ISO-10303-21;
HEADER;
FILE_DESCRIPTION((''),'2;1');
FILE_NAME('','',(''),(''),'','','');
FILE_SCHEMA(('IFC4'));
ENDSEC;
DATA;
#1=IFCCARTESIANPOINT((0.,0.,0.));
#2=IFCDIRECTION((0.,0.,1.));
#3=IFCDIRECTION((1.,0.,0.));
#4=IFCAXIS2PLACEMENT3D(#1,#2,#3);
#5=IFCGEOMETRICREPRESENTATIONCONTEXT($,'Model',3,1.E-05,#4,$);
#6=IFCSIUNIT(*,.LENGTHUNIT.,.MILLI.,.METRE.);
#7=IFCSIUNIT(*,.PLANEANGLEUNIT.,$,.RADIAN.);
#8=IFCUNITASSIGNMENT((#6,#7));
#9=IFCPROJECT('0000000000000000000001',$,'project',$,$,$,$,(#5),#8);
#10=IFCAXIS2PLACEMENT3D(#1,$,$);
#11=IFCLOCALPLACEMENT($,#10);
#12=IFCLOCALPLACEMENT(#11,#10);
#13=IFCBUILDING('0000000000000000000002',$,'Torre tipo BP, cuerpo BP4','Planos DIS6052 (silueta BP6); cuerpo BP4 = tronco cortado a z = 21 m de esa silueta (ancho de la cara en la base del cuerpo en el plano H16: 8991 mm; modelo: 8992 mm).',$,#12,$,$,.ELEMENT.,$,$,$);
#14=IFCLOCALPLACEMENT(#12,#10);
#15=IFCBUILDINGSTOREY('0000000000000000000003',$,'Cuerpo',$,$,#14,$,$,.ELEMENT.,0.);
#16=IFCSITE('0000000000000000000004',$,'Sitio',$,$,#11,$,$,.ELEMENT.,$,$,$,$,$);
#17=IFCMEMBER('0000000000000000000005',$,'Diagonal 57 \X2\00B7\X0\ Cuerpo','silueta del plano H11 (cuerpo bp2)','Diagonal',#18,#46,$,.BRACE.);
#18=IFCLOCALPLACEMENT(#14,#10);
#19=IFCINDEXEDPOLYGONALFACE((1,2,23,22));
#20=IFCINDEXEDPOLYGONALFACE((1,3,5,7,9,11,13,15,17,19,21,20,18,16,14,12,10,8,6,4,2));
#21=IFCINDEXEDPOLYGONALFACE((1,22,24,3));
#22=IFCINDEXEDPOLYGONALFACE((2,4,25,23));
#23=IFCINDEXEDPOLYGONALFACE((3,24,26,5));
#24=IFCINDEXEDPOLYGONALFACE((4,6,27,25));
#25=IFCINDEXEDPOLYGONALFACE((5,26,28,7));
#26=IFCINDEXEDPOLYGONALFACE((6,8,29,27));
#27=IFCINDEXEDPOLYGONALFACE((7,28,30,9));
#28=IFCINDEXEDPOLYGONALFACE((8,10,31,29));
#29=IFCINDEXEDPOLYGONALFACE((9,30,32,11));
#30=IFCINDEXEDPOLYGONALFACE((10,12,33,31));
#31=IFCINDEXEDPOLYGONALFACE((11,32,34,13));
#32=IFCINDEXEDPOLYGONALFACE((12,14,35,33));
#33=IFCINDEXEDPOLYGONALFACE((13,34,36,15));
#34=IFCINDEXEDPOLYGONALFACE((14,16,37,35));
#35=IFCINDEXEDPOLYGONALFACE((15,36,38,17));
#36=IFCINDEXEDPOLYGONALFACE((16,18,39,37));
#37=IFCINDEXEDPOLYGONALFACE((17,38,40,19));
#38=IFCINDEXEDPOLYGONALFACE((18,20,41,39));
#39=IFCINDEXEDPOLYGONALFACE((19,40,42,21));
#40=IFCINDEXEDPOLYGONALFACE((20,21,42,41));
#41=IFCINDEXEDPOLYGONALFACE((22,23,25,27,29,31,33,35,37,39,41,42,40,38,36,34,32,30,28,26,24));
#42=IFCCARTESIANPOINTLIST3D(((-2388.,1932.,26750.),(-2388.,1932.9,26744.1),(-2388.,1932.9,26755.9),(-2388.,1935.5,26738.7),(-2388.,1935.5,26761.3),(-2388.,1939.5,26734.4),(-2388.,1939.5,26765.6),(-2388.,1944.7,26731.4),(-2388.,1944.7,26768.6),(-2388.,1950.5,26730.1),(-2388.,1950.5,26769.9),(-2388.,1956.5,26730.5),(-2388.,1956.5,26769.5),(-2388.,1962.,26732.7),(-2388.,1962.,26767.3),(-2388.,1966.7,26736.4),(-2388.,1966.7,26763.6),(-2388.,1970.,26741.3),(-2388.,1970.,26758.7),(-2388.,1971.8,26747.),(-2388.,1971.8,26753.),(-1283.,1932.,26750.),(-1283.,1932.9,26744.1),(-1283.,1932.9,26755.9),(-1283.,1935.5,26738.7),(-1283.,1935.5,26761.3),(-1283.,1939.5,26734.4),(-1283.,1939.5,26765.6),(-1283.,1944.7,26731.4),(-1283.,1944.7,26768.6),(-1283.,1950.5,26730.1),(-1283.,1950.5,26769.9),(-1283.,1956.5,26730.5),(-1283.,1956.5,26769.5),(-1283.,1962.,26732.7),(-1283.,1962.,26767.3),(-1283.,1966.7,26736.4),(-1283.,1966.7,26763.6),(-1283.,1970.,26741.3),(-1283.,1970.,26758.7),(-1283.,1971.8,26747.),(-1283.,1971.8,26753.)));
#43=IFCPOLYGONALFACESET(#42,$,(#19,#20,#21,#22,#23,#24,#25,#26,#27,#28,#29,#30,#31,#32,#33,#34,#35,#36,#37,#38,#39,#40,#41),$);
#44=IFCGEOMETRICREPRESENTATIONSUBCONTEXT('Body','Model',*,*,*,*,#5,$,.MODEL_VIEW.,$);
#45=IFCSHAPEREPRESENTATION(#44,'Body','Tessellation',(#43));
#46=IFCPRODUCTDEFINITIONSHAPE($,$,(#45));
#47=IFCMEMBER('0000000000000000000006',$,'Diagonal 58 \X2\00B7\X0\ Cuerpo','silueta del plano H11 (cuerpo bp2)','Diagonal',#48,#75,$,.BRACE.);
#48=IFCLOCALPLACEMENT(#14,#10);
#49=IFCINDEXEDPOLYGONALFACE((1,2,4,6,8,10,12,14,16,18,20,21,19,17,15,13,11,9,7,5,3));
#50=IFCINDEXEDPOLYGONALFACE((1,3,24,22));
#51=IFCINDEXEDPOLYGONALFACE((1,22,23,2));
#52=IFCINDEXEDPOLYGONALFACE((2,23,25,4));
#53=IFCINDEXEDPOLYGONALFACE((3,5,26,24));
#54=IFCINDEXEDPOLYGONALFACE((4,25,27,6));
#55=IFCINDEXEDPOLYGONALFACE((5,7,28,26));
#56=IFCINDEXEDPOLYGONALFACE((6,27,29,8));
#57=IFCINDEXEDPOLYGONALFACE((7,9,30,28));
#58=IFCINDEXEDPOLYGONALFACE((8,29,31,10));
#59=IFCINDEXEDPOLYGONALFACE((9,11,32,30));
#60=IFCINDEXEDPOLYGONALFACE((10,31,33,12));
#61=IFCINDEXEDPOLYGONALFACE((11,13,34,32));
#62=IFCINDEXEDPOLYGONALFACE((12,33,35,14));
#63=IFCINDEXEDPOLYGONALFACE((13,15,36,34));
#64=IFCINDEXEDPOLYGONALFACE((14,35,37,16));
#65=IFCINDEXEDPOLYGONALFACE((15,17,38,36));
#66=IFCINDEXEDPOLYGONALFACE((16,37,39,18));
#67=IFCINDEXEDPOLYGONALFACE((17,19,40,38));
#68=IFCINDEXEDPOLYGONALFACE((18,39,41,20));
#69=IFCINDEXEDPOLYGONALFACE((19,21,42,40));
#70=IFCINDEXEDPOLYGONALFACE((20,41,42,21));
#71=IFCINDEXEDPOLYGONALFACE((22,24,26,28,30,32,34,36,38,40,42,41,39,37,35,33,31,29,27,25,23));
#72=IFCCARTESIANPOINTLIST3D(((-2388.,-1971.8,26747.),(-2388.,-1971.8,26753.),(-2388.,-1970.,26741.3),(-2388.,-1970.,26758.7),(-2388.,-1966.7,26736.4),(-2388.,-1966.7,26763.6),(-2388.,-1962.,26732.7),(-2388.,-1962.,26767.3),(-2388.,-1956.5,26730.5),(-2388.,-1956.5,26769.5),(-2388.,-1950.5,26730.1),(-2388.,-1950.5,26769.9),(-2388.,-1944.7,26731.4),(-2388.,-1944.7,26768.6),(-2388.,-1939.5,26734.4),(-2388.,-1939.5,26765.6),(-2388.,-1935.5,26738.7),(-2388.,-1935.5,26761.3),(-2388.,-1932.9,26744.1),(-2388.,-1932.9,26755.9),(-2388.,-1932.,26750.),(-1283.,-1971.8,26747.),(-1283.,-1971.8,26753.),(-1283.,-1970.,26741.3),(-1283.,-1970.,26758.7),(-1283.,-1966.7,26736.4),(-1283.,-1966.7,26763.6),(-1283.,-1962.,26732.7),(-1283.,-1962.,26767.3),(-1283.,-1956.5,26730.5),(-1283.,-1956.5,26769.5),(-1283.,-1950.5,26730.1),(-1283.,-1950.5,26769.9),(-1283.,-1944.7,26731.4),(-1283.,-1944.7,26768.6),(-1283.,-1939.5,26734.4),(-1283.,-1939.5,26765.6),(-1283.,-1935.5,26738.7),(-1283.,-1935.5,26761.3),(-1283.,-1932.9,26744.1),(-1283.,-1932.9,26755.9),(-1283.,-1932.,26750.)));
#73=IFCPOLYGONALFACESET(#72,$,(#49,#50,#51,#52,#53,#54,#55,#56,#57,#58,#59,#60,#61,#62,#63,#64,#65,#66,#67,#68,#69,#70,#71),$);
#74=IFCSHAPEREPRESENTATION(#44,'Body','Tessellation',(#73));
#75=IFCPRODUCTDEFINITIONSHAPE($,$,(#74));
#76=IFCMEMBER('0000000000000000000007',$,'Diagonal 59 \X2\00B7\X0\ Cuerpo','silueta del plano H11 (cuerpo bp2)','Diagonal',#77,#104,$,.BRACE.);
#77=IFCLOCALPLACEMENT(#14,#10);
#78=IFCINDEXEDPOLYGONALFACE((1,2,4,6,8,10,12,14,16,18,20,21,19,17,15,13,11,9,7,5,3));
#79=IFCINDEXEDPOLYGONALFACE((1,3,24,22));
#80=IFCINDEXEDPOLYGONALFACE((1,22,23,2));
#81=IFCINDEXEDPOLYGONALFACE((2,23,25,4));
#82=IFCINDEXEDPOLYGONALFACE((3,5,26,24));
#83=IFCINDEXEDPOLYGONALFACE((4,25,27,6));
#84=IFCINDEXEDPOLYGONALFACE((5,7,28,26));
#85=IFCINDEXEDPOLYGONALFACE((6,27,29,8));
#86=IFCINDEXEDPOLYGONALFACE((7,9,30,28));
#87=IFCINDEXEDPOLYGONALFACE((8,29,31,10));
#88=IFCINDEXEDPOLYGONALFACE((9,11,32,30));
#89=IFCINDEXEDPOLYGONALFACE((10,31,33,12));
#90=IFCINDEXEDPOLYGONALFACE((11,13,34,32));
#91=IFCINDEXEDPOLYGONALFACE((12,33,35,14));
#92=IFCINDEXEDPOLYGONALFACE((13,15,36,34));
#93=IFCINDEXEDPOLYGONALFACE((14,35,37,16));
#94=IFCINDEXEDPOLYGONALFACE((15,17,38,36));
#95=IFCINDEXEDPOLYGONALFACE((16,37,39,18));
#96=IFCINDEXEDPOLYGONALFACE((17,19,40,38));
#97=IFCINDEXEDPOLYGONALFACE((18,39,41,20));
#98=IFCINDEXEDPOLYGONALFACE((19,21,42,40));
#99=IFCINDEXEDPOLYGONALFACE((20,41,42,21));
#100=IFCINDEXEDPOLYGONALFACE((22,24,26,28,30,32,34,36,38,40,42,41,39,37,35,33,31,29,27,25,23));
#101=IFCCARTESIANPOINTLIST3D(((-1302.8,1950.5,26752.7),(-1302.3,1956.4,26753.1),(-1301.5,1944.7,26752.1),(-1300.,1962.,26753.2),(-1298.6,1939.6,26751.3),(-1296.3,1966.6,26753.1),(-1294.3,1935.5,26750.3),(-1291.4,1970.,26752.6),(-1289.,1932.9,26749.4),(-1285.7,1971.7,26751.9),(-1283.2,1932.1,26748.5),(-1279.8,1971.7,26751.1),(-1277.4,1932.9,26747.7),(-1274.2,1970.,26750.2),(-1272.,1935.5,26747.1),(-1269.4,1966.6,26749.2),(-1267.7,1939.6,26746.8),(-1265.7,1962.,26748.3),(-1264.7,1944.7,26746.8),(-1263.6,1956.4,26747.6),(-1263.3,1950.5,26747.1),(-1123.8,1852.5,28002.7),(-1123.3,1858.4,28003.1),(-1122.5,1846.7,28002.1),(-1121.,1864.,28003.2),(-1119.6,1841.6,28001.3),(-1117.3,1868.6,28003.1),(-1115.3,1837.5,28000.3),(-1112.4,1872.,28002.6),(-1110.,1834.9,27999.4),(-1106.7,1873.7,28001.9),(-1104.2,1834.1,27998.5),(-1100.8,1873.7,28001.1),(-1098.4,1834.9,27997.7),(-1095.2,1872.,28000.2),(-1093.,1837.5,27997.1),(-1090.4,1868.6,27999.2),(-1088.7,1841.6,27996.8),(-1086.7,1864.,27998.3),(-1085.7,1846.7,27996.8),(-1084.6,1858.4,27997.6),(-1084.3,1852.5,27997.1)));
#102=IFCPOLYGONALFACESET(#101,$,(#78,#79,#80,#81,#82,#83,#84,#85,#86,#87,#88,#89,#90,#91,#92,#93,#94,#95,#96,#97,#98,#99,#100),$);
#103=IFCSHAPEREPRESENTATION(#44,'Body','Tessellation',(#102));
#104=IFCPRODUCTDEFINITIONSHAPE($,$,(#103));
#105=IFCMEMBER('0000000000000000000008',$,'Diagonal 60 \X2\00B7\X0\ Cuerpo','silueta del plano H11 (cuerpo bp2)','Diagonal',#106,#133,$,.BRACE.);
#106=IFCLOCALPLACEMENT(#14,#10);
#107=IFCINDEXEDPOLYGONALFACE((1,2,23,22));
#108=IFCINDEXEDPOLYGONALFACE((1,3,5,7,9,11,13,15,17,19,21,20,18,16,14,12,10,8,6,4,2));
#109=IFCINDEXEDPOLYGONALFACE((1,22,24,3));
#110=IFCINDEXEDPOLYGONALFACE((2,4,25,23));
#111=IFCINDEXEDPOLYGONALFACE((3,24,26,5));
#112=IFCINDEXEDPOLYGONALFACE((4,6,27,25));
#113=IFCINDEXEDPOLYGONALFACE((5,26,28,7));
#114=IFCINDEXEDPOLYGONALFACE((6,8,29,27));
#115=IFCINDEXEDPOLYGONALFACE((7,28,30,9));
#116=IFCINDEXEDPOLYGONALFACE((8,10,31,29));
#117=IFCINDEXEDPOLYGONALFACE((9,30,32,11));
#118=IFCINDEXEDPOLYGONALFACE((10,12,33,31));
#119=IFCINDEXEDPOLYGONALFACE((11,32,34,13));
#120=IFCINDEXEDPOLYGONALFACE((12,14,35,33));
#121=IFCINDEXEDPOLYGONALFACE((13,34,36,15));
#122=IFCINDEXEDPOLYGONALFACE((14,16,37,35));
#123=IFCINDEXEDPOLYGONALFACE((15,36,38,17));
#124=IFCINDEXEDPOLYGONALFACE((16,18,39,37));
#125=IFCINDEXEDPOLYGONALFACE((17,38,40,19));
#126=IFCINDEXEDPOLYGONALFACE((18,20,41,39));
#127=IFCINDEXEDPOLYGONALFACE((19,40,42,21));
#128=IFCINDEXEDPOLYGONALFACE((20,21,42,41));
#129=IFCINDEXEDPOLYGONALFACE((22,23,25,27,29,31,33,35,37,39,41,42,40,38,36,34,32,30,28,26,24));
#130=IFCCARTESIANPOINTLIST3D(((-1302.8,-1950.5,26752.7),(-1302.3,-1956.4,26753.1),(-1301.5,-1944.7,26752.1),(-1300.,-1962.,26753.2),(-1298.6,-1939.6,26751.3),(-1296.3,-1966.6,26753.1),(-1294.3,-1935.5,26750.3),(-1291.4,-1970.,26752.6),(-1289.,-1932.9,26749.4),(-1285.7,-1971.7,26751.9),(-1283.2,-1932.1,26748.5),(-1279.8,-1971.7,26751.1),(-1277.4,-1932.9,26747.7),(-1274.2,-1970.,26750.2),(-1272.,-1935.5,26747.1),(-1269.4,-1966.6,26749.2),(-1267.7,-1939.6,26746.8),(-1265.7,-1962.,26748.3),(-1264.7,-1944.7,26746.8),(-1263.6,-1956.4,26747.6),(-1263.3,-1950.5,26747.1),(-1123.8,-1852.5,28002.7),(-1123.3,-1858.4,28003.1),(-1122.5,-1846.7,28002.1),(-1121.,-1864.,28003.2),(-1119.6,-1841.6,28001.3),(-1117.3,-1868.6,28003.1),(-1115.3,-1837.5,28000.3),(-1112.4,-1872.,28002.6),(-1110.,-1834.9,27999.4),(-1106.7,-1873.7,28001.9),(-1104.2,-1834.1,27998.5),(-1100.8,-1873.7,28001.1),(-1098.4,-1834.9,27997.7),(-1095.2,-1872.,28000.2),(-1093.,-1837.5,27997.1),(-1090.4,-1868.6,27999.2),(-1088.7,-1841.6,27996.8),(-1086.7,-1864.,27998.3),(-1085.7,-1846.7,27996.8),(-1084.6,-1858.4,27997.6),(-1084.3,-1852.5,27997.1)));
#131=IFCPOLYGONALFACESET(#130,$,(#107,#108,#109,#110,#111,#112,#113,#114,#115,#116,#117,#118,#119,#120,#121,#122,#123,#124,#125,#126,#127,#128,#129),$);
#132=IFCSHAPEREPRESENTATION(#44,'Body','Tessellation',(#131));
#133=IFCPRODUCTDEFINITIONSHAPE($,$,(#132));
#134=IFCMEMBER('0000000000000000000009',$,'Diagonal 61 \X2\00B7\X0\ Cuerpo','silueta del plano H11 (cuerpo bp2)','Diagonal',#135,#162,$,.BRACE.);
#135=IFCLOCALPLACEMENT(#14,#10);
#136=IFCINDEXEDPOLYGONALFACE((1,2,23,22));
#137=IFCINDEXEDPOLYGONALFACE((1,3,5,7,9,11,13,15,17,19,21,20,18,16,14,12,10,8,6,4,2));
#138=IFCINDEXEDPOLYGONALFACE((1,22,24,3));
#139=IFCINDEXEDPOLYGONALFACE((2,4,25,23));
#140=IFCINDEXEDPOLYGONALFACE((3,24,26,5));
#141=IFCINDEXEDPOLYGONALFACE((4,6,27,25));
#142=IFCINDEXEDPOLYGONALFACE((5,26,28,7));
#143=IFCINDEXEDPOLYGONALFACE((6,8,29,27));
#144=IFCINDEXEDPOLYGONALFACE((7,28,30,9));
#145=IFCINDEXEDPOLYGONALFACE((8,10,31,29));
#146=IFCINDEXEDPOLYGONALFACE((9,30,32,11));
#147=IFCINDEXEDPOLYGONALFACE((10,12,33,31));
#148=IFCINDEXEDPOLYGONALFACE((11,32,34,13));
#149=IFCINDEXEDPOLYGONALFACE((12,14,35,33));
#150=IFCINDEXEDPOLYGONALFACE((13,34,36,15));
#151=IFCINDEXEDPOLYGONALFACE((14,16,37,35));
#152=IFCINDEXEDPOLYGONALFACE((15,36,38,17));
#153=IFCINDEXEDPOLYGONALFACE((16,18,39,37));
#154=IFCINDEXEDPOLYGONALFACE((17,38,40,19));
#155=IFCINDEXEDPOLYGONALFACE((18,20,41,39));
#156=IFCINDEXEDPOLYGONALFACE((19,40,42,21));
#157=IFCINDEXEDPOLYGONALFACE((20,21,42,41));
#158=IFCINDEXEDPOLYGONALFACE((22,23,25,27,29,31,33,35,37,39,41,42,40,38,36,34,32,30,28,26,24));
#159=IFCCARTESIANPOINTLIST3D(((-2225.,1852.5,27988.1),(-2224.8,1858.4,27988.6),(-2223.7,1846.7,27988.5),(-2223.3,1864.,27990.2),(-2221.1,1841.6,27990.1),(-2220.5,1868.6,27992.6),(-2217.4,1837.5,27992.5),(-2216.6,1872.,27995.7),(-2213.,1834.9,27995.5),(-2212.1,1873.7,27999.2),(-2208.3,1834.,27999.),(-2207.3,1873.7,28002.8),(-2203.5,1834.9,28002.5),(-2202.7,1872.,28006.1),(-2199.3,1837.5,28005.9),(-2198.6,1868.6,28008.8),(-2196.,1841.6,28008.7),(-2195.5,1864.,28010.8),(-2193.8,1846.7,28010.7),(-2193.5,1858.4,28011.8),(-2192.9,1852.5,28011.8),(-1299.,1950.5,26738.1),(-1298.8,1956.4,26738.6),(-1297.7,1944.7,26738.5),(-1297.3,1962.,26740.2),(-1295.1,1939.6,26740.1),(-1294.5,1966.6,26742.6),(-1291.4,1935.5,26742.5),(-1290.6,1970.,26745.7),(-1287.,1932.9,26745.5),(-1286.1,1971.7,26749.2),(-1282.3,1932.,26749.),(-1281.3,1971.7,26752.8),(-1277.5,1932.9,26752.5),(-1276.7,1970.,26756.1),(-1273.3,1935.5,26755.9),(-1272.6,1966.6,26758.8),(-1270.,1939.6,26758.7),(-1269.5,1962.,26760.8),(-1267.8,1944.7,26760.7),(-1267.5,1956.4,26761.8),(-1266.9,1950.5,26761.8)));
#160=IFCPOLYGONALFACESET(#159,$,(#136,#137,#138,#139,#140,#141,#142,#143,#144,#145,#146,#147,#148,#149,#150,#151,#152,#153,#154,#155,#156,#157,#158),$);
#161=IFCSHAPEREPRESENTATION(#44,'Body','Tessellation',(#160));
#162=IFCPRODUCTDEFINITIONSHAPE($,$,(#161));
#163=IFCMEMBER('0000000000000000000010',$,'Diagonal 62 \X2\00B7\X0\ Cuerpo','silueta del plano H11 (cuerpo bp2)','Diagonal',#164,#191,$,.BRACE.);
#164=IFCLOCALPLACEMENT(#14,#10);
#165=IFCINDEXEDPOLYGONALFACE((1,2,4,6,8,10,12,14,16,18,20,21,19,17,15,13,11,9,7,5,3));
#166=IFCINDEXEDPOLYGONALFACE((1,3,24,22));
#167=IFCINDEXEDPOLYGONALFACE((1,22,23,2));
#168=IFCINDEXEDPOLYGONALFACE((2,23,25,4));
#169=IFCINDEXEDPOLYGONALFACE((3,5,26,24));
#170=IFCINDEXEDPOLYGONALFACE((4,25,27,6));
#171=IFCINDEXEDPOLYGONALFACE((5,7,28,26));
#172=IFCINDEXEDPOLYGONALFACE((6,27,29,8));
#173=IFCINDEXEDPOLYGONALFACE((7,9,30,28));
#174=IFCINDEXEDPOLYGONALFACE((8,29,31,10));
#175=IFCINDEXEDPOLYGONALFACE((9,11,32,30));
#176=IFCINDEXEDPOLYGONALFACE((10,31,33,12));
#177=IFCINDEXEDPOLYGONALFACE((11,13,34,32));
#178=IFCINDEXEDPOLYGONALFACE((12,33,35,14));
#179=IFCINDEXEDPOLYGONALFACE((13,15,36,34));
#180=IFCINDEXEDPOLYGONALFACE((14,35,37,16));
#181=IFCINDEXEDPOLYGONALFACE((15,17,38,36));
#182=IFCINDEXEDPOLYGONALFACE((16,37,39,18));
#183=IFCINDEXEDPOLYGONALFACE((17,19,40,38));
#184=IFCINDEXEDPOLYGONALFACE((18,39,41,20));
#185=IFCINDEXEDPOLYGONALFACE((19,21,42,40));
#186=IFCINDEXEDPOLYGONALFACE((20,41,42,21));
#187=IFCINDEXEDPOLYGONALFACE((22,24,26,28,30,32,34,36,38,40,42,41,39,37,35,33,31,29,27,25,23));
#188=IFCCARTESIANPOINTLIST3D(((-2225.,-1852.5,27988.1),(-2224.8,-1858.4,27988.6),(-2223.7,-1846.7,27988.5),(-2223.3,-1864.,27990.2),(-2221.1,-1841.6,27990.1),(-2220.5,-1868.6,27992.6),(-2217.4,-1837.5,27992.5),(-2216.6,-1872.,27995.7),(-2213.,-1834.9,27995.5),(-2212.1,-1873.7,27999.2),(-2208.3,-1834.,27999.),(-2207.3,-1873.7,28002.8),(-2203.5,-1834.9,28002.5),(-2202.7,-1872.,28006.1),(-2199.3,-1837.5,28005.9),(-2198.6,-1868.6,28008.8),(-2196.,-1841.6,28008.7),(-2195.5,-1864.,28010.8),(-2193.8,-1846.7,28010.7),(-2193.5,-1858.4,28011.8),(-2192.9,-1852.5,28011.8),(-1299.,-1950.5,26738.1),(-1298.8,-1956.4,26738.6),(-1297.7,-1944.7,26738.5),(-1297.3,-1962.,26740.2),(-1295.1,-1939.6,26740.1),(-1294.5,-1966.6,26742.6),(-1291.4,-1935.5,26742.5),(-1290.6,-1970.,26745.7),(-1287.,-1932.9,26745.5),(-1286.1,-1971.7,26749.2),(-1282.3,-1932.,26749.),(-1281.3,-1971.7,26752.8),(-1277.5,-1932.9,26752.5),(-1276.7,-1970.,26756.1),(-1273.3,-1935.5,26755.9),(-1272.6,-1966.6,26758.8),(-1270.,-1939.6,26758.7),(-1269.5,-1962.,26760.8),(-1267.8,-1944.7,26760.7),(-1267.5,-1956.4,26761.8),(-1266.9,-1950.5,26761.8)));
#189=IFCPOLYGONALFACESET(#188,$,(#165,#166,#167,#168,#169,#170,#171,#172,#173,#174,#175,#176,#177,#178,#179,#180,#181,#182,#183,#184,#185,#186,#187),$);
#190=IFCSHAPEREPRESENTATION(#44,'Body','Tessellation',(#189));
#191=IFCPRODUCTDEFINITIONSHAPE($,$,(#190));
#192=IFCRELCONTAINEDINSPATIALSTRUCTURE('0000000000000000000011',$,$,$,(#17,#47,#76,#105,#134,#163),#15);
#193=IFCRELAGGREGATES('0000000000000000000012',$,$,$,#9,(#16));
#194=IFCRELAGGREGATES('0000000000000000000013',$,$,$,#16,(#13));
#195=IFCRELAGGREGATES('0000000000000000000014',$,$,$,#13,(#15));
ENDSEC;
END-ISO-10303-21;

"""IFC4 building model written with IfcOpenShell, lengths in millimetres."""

from ifc_helpers import new_model, si_unit, frame, origin, origin_with_axes, place, context, subcontext, project, spatial, circle, extrude, element, save


model = new_model("IFC4")

# Units and contexts
model_context = context("Model", 3, precision=1e-05, world=origin_with_axes())
body_context = subcontext(model_context, "Body", "Model", "MODEL_VIEW")
ifc_project = project(units=[si_unit("LENGTHUNIT", "METRE", prefix="MILLI"), si_unit("PLANEANGLEUNIT", "RADIAN")], contexts=[model_context])

# Site, building, storey
site_placement = place(None, origin())
site = spatial("IfcSite", under=ifc_project, at=site_placement, Name="Sitio", CompositionType="ELEMENT")
building_placement = place(site_placement, origin())
building = spatial("IfcBuilding", under=site, at=building_placement, Name="Torre tipo BP, cuerpo BP4", Description="Planos DIS6052 (silueta BP6); cuerpo BP4 = tronco cortado a z = 21 m de esa silueta (ancho de la cara en la base del cuerpo en el plano H16: 8991 mm; modelo: 8992 mm).", CompositionType="ELEMENT")
storey_placement = place(building_placement, origin())
storey = spatial("IfcBuildingStorey", under=building, at=storey_placement, Name="Cuerpo", CompositionType="ELEMENT", Elevation=0.0)

# Members
for number, where, z_axis, x_axis, name in (
    (1, (-2388.0, 1952.0, 26750.0), (1.0, 0.0, 0.0), (0.0, -1.0, 0.0), "Diagonal 57 · Cuerpo"),
    (2, (-2388.0, -1952.0, 26750.0), (1.0, 0.0, 0.0), (0.0, 1.0, 0.0), "Diagonal 58 · Cuerpo"),
):
    element("IfcMember", number, at=place(storey_placement, frame(where, z_axis=z_axis, x_axis=x_axis)), inside=storey, Name=name, Description="silueta del plano H11 (cuerpo bp2)", ObjectType="Diagonal", PredefinedType="BRACE", context=body_context, shape_type="SweptSolid", body=[
        extrude(circle(Radius=20.0), None, (0.0, 0.0, 1.0), 1105.0),
    ])
for number, where, z_axis, x_axis, name in (
    (3, (-1283.0, 1952.0, 26750.0), (0.141329, -0.077376, 0.986934), (-0.010968, -0.997002, -0.076594), "Diagonal 59 · Cuerpo"),
    (4, (-1283.0, -1952.0, 26750.0), (0.141329, 0.077376, 0.986934), (-0.010968, 0.997002, -0.076594), "Diagonal 60 · Cuerpo"),
):
    element("IfcMember", number, at=place(storey_placement, frame(where, z_axis=z_axis, x_axis=x_axis)), inside=storey, Name=name, Description="silueta del plano H11 (cuerpo bp2)", ObjectType="Diagonal", PredefinedType="BRACE", context=body_context, shape_type="SweptSolid", body=[
        extrude(circle(Radius=20.0), None, (0.0, 0.0, 1.0), 1266.5),
    ])
for number, where, z_axis, x_axis, name in (
    (5, (-2209.0, 1854.0, 28000.0), (0.594081, 0.062872, -0.801945), (0.037425, -0.998022, -0.05052), "Diagonal 61 · Cuerpo"),
    (6, (-2209.0, -1854.0, 28000.0), (0.594081, -0.062872, -0.801945), (0.037425, 0.998022, -0.05052), "Diagonal 62 · Cuerpo"),
):
    element("IfcMember", number, at=place(storey_placement, frame(where, z_axis=z_axis, x_axis=x_axis)), inside=storey, Name=name, Description="silueta del plano H11 (cuerpo bp2)", ObjectType="Diagonal", PredefinedType="BRACE", context=body_context, shape_type="SweptSolid", body=[
        extrude(circle(Radius=20.0), None, (0.0, 0.0, 1.0), 1558.7),
    ])

save(model, "model.ifc")
